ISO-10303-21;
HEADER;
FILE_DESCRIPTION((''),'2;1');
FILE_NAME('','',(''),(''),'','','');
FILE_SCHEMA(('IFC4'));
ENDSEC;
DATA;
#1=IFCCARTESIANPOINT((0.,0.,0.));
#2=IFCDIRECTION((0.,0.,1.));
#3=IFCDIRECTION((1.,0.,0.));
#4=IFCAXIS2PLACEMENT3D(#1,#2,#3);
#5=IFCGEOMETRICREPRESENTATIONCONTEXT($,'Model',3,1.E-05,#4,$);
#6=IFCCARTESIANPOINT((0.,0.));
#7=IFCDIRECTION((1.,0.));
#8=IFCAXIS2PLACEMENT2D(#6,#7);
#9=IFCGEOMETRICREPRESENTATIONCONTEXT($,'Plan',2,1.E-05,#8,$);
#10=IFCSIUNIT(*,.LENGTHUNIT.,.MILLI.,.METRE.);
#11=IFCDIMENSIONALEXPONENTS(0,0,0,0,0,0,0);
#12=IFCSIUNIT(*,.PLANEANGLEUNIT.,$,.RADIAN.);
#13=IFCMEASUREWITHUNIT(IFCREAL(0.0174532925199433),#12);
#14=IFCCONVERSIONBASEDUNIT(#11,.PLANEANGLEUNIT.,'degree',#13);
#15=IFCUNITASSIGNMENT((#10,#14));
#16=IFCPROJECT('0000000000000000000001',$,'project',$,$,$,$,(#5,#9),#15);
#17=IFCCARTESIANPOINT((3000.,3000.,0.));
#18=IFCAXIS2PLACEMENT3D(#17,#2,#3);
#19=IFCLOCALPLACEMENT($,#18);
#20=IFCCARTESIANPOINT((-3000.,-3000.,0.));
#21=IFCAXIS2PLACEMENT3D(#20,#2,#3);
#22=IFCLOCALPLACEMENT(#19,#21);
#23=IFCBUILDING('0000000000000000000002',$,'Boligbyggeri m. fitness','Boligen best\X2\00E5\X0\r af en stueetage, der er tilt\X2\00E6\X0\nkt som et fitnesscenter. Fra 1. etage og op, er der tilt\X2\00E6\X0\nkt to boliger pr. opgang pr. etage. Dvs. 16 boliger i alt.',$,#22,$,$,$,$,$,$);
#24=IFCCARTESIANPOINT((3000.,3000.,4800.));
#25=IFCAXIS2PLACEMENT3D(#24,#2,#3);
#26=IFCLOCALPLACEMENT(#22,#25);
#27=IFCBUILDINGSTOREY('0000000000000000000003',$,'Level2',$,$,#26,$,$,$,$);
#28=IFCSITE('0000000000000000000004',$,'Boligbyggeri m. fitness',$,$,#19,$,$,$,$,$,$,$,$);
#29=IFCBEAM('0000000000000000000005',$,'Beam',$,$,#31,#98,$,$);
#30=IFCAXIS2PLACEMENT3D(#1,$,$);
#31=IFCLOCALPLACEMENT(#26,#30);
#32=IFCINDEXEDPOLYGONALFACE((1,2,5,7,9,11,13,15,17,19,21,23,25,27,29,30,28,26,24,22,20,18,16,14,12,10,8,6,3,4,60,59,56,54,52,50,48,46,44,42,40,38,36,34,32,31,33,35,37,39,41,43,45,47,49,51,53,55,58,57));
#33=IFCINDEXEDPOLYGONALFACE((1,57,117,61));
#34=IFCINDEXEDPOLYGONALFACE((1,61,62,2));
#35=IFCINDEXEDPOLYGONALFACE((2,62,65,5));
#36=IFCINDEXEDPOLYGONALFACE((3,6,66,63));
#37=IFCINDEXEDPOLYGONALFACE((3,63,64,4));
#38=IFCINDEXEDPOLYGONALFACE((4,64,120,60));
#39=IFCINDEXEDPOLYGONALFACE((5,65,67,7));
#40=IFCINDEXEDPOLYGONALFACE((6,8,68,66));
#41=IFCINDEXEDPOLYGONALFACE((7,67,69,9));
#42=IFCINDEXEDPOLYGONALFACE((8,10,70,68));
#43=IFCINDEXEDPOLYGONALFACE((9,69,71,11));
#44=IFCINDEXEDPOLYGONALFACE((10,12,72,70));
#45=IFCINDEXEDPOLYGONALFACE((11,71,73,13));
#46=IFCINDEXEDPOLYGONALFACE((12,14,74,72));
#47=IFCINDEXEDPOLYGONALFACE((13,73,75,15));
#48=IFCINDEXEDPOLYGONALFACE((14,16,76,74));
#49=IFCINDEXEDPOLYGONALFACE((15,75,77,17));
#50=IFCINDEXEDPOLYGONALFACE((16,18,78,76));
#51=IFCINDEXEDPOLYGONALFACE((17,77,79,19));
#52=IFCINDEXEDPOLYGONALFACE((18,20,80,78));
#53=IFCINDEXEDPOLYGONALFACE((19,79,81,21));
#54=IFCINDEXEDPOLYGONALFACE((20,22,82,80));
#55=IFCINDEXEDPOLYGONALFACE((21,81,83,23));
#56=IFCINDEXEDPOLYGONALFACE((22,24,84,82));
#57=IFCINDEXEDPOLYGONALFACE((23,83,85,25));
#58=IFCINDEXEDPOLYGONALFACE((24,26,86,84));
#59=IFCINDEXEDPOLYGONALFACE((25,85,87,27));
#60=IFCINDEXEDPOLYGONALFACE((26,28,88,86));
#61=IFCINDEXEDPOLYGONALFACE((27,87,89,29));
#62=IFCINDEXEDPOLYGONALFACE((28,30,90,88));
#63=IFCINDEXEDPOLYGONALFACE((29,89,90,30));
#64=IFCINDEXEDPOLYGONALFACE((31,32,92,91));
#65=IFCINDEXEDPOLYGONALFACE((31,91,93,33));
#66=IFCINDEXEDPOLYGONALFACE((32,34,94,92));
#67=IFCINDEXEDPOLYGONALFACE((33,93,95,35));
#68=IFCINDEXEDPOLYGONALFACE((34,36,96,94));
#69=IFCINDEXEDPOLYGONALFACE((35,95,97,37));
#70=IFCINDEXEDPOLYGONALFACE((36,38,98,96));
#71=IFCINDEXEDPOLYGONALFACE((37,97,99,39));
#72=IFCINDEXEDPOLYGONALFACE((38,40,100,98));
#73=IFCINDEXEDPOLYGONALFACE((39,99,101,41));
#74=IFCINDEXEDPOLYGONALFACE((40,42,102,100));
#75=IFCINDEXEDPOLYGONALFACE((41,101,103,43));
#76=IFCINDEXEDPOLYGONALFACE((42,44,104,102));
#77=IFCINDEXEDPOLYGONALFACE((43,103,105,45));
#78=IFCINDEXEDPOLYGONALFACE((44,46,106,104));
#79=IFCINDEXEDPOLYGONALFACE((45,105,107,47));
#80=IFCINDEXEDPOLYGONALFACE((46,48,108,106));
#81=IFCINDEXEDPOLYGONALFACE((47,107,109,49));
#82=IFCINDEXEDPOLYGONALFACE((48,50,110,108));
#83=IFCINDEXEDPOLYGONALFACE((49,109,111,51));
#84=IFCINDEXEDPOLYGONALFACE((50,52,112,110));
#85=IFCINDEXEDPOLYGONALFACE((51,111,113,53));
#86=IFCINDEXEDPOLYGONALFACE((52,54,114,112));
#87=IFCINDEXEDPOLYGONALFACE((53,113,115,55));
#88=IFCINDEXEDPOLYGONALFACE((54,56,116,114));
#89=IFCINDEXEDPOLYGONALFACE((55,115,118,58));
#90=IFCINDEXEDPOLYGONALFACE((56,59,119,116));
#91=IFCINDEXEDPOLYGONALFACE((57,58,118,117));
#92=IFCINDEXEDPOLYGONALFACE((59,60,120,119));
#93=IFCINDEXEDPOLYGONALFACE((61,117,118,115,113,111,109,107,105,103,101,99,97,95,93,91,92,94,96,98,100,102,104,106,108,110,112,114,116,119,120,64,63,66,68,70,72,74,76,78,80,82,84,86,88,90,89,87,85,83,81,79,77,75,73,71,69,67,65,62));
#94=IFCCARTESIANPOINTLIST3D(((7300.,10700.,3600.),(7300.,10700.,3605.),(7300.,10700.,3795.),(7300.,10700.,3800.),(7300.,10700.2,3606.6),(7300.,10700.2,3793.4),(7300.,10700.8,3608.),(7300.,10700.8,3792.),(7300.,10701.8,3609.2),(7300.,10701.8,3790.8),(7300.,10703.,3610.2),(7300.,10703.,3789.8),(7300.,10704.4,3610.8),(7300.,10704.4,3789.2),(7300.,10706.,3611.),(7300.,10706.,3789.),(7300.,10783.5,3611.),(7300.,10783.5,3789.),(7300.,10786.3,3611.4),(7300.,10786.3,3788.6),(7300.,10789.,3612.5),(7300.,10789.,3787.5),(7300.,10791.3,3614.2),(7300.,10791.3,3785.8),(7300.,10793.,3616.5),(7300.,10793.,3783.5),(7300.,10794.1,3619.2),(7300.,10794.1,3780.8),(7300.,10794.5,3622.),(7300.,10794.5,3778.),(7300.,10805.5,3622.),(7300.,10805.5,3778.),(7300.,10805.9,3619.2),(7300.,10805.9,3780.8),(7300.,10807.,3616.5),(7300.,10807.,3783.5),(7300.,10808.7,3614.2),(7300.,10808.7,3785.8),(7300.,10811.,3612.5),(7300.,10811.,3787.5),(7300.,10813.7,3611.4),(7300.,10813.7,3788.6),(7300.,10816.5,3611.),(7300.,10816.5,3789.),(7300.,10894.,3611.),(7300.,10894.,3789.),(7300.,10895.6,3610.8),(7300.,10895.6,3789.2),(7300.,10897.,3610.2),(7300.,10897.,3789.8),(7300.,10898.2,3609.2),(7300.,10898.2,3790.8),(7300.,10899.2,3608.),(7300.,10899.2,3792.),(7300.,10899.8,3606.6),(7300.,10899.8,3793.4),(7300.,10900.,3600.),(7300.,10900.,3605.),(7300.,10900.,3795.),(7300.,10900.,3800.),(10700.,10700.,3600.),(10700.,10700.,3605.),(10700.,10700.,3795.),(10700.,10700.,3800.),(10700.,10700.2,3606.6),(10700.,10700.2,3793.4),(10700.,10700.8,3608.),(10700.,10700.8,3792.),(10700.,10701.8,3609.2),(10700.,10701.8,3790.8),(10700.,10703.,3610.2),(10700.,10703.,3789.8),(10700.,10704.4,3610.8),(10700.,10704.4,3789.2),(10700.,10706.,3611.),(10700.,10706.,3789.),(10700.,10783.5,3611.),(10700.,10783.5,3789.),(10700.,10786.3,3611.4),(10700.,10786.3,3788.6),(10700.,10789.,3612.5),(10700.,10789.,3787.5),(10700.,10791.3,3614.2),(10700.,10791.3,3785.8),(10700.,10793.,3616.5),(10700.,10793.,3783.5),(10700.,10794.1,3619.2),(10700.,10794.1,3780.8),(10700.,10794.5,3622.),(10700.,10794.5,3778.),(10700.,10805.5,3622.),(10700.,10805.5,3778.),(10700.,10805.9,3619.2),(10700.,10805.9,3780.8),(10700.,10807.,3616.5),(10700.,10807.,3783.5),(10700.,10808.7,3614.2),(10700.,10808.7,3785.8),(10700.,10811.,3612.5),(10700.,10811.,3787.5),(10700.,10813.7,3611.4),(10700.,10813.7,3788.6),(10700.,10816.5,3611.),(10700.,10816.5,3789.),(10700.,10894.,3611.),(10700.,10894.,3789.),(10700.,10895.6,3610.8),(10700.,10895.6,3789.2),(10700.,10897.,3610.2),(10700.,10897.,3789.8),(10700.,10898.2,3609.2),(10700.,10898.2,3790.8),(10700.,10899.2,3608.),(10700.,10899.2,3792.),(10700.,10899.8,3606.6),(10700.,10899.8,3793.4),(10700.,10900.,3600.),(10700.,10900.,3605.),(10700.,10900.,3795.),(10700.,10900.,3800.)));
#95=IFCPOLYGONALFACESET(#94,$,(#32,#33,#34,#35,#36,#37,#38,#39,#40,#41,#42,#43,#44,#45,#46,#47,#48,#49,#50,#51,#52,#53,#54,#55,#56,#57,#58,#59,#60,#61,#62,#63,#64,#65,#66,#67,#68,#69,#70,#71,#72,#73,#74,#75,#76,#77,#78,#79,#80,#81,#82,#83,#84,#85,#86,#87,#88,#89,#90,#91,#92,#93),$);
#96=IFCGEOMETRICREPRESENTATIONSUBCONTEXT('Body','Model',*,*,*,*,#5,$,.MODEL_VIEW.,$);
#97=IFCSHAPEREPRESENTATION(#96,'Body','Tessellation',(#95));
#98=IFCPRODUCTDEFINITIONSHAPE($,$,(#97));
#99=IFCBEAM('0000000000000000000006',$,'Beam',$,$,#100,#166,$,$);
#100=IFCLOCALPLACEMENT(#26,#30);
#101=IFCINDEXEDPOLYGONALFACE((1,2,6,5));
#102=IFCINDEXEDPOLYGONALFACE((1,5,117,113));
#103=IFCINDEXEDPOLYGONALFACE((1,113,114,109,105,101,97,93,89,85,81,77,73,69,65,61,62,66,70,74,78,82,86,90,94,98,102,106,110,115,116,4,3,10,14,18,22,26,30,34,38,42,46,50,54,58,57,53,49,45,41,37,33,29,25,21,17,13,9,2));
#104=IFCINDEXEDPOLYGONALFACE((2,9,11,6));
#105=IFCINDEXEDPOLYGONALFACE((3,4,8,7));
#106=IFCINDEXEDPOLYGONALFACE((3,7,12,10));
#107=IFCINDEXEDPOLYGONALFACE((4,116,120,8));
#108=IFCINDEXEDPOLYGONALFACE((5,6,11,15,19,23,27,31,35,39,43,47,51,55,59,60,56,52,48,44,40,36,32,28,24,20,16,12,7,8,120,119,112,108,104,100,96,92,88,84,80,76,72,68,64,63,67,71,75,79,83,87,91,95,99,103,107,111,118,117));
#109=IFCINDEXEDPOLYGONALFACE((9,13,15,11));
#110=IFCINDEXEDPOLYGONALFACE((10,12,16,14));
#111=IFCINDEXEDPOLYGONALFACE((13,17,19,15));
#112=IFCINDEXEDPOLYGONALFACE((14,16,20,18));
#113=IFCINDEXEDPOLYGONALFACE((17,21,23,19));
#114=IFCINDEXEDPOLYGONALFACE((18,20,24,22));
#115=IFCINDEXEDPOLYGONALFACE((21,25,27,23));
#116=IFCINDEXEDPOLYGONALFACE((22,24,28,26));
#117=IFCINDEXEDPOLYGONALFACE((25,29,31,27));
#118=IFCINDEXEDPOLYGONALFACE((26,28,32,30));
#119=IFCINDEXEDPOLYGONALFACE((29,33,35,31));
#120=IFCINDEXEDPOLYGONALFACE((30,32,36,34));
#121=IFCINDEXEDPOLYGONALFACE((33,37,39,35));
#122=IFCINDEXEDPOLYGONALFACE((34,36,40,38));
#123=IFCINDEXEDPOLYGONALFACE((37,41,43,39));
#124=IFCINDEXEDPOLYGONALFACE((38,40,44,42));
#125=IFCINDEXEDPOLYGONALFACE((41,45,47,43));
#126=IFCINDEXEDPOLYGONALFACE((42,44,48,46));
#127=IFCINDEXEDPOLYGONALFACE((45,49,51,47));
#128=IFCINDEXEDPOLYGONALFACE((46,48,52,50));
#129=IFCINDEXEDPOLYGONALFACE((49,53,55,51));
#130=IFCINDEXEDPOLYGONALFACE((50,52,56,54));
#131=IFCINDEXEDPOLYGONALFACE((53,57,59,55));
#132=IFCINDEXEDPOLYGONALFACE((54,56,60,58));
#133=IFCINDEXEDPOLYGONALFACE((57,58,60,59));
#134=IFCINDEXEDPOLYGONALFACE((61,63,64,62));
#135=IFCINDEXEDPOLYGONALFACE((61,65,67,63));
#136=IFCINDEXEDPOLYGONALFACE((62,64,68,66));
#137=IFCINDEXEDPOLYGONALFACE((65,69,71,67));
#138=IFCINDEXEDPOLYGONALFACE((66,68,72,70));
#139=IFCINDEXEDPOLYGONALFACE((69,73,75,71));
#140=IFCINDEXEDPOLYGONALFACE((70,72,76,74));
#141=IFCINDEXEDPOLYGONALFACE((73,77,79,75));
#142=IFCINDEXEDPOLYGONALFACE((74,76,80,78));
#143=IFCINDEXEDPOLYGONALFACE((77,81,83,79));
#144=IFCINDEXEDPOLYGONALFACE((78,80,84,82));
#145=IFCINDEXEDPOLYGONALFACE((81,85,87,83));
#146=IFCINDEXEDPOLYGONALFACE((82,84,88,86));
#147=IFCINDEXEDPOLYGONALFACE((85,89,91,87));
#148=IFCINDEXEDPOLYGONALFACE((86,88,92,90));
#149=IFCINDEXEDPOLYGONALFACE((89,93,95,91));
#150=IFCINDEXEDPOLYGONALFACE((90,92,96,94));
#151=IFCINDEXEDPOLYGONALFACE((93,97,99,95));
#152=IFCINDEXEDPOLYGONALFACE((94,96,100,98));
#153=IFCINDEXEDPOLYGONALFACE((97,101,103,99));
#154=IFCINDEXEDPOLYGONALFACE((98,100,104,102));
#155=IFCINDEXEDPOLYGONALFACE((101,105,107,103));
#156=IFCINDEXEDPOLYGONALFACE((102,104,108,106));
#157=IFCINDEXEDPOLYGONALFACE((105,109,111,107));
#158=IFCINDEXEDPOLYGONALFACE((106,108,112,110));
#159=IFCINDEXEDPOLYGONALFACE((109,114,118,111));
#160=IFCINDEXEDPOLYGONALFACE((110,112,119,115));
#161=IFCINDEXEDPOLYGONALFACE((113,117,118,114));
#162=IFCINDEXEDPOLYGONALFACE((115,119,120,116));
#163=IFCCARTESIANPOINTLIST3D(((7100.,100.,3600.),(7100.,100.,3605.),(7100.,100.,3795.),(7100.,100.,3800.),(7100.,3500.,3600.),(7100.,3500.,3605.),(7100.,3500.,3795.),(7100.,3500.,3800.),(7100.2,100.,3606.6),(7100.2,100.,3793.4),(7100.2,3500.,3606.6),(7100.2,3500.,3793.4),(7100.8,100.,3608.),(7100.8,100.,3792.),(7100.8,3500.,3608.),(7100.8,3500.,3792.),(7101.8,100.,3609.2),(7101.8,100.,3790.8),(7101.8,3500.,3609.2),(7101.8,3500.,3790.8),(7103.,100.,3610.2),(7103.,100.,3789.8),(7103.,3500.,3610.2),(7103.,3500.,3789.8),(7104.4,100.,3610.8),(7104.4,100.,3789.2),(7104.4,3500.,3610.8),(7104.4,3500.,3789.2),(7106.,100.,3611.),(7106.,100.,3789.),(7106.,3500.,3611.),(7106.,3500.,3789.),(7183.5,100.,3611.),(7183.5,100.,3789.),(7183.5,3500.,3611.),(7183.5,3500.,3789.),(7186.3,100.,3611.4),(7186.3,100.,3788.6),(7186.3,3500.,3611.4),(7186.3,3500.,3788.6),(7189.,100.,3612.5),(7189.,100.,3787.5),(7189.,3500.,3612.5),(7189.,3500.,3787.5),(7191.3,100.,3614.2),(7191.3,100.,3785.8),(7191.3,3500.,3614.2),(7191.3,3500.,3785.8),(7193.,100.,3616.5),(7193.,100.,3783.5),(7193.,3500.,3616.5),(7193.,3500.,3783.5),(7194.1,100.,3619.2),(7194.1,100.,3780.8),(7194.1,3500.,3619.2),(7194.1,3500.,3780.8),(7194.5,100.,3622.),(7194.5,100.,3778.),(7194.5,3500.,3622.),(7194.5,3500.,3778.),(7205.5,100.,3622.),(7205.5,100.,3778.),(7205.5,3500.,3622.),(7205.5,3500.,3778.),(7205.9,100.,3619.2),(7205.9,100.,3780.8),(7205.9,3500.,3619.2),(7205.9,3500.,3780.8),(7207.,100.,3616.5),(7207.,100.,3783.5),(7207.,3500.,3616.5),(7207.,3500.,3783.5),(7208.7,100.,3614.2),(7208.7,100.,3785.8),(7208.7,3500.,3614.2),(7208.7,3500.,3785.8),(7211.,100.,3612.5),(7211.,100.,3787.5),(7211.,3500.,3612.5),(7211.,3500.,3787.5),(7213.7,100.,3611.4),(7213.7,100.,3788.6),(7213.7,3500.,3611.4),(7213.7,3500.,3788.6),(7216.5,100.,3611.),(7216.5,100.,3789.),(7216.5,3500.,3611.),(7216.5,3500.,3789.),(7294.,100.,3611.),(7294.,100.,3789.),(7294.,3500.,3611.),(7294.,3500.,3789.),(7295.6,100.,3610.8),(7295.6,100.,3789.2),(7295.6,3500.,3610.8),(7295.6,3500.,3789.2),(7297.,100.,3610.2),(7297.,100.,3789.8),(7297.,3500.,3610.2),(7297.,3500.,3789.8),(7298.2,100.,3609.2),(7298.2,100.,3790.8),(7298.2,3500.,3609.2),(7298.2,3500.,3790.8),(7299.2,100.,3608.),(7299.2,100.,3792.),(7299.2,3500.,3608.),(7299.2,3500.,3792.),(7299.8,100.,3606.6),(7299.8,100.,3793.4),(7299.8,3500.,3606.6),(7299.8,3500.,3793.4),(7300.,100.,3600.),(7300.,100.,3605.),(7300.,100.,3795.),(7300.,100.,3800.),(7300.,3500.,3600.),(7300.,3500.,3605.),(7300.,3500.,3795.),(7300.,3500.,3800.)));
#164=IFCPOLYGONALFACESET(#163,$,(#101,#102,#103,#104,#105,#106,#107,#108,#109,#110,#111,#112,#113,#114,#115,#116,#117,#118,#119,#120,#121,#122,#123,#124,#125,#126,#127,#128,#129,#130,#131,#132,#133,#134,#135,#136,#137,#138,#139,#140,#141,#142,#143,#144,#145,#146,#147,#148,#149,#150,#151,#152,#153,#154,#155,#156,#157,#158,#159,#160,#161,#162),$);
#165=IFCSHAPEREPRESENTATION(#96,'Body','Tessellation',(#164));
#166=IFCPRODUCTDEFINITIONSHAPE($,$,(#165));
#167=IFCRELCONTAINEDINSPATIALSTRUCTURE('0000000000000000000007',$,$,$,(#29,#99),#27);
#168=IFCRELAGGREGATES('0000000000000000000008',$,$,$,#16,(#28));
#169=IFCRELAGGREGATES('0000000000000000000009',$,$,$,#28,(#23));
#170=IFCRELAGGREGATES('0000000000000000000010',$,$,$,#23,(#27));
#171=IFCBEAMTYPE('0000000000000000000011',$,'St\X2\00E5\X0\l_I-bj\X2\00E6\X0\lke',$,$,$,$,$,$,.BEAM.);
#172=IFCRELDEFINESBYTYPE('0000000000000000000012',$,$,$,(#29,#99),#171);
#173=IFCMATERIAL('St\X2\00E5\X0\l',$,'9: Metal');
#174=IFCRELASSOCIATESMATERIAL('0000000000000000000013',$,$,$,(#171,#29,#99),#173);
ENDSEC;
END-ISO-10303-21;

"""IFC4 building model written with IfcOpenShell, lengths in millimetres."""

from ifc_helpers import new_model, entity, si_unit, converted_unit, frame, origin_with_axes, origin_2d_with_axis, place, context, subcontext, project, spatial, i_section, extrude, material, material_profile, profile_set, profile_usage, type_object, element, save


model = new_model("IFC4")

# Units and contexts
model_context = context("Model", 3, precision=1e-05, world=origin_with_axes())
plan_context = context("Plan", 2, precision=1e-05, world=origin_2d_with_axis())
body_context = subcontext(model_context, "Body", "Model", "MODEL_VIEW")
ifc_project = project(units=[si_unit("LENGTHUNIT", "METRE", prefix="MILLI"), converted_unit("PLANEANGLEUNIT", "degree", entity("IfcReal", 0.0174532925199433), si_unit("PLANEANGLEUNIT", "RADIAN"), dimensions=[0, 0, 0, 0, 0, 0, 0])], contexts=[model_context, plan_context])

# Site, building, storey
site_placement = place(None, frame((3000.0, 3000.0, 0.0), z_axis=(0.0, 0.0, 1.0), x_axis=(1.0, 0.0, 0.0)))
site = spatial("IfcSite", under=ifc_project, at=site_placement, Name="Boligbyggeri m. fitness")
building_placement = place(site_placement, frame((-3000.0, -3000.0, 0.0), z_axis=(0.0, 0.0, 1.0), x_axis=(1.0, 0.0, 0.0)))
building = spatial("IfcBuilding", under=site, at=building_placement, Name="Boligbyggeri m. fitness", Description="Boligen består af en stueetage, der er tiltænkt som et fitnesscenter. Fra 1. etage og op, er der tiltænkt to boliger pr. opgang pr. etage. Dvs. 16 boliger i alt.")
storey_placement = place(building_placement, frame((3000.0, 3000.0, 4800.0), z_axis=(0.0, 0.0, 1.0), x_axis=(1.0, 0.0, 0.0)))
storey = spatial("IfcBuildingStorey", under=building, at=storey_placement, Name="Level2")

# Beams
ifc_material_1 = material(Name="Stål", Category="9: Metal")
ifc_material_profile_1 = material_profile(ifc_material_1, i_section(OverallWidth=200.0, OverallDepth=200.0, WebThickness=11.0, FlangeThickness=11.0, FilletRadius=11.0, FlangeEdgeRadius=6.0), Name="Stål", Category="9: Metal")
ifc_profile_set_1 = profile_set([ifc_material_profile_1], Name="NY_I-Profil")
beam_type = type_object("IfcBeamType", Name="Stål_I-bjælke", PredefinedType="BEAM", material=ifc_profile_set_1)
ifc_profile_usage_1 = profile_usage(ifc_profile_set_1, cardinal=7)
beam_1_placement = place(storey_placement, frame((7300.0, 10900.0, 3800.0), z_axis=(1.0, 0.0, 0.0), x_axis=(0.0, 1.0, 0.0)))
element("IfcBeam", 1, at=beam_1_placement, inside=storey, type_object=beam_type, material=ifc_profile_usage_1, Name="Beam", context=body_context, shape_type="SweptSolid", body=[
    extrude(i_section(OverallWidth=200.0, OverallDepth=200.0, WebThickness=11.0, FlangeThickness=11.0, FilletRadius=11.0, FlangeEdgeRadius=6.0), frame((-100.0, -100.0, 0.0), z_axis=(0.0, 0.0, 1.0), x_axis=(1.0, 0.0, 0.0)), (0.0, 0.0, 1.0), 3400.0),
])
ifc_profile_usage_2 = profile_usage(ifc_profile_set_1, cardinal=9)
beam_2_placement = place(storey_placement, frame((7300.0, 100.0, 3800.0), z_axis=(0.0, 1.0, 0.0), x_axis=(-1.0, 0.0, 0.0)))
element("IfcBeam", 2, at=beam_2_placement, inside=storey, type_object=beam_type, material=ifc_profile_usage_2, Name="Beam", context=body_context, shape_type="SweptSolid", body=[
    extrude(i_section(OverallWidth=200.0, OverallDepth=200.0, WebThickness=11.0, FlangeThickness=11.0, FilletRadius=11.0, FlangeEdgeRadius=6.0), frame((100.0, -100.0, 0.0), z_axis=(0.0, 0.0, 1.0), x_axis=(1.0, 0.0, 0.0)), (0.0, 0.0, 1.0), 3400.0),
])

save(model, "model.ifc")
